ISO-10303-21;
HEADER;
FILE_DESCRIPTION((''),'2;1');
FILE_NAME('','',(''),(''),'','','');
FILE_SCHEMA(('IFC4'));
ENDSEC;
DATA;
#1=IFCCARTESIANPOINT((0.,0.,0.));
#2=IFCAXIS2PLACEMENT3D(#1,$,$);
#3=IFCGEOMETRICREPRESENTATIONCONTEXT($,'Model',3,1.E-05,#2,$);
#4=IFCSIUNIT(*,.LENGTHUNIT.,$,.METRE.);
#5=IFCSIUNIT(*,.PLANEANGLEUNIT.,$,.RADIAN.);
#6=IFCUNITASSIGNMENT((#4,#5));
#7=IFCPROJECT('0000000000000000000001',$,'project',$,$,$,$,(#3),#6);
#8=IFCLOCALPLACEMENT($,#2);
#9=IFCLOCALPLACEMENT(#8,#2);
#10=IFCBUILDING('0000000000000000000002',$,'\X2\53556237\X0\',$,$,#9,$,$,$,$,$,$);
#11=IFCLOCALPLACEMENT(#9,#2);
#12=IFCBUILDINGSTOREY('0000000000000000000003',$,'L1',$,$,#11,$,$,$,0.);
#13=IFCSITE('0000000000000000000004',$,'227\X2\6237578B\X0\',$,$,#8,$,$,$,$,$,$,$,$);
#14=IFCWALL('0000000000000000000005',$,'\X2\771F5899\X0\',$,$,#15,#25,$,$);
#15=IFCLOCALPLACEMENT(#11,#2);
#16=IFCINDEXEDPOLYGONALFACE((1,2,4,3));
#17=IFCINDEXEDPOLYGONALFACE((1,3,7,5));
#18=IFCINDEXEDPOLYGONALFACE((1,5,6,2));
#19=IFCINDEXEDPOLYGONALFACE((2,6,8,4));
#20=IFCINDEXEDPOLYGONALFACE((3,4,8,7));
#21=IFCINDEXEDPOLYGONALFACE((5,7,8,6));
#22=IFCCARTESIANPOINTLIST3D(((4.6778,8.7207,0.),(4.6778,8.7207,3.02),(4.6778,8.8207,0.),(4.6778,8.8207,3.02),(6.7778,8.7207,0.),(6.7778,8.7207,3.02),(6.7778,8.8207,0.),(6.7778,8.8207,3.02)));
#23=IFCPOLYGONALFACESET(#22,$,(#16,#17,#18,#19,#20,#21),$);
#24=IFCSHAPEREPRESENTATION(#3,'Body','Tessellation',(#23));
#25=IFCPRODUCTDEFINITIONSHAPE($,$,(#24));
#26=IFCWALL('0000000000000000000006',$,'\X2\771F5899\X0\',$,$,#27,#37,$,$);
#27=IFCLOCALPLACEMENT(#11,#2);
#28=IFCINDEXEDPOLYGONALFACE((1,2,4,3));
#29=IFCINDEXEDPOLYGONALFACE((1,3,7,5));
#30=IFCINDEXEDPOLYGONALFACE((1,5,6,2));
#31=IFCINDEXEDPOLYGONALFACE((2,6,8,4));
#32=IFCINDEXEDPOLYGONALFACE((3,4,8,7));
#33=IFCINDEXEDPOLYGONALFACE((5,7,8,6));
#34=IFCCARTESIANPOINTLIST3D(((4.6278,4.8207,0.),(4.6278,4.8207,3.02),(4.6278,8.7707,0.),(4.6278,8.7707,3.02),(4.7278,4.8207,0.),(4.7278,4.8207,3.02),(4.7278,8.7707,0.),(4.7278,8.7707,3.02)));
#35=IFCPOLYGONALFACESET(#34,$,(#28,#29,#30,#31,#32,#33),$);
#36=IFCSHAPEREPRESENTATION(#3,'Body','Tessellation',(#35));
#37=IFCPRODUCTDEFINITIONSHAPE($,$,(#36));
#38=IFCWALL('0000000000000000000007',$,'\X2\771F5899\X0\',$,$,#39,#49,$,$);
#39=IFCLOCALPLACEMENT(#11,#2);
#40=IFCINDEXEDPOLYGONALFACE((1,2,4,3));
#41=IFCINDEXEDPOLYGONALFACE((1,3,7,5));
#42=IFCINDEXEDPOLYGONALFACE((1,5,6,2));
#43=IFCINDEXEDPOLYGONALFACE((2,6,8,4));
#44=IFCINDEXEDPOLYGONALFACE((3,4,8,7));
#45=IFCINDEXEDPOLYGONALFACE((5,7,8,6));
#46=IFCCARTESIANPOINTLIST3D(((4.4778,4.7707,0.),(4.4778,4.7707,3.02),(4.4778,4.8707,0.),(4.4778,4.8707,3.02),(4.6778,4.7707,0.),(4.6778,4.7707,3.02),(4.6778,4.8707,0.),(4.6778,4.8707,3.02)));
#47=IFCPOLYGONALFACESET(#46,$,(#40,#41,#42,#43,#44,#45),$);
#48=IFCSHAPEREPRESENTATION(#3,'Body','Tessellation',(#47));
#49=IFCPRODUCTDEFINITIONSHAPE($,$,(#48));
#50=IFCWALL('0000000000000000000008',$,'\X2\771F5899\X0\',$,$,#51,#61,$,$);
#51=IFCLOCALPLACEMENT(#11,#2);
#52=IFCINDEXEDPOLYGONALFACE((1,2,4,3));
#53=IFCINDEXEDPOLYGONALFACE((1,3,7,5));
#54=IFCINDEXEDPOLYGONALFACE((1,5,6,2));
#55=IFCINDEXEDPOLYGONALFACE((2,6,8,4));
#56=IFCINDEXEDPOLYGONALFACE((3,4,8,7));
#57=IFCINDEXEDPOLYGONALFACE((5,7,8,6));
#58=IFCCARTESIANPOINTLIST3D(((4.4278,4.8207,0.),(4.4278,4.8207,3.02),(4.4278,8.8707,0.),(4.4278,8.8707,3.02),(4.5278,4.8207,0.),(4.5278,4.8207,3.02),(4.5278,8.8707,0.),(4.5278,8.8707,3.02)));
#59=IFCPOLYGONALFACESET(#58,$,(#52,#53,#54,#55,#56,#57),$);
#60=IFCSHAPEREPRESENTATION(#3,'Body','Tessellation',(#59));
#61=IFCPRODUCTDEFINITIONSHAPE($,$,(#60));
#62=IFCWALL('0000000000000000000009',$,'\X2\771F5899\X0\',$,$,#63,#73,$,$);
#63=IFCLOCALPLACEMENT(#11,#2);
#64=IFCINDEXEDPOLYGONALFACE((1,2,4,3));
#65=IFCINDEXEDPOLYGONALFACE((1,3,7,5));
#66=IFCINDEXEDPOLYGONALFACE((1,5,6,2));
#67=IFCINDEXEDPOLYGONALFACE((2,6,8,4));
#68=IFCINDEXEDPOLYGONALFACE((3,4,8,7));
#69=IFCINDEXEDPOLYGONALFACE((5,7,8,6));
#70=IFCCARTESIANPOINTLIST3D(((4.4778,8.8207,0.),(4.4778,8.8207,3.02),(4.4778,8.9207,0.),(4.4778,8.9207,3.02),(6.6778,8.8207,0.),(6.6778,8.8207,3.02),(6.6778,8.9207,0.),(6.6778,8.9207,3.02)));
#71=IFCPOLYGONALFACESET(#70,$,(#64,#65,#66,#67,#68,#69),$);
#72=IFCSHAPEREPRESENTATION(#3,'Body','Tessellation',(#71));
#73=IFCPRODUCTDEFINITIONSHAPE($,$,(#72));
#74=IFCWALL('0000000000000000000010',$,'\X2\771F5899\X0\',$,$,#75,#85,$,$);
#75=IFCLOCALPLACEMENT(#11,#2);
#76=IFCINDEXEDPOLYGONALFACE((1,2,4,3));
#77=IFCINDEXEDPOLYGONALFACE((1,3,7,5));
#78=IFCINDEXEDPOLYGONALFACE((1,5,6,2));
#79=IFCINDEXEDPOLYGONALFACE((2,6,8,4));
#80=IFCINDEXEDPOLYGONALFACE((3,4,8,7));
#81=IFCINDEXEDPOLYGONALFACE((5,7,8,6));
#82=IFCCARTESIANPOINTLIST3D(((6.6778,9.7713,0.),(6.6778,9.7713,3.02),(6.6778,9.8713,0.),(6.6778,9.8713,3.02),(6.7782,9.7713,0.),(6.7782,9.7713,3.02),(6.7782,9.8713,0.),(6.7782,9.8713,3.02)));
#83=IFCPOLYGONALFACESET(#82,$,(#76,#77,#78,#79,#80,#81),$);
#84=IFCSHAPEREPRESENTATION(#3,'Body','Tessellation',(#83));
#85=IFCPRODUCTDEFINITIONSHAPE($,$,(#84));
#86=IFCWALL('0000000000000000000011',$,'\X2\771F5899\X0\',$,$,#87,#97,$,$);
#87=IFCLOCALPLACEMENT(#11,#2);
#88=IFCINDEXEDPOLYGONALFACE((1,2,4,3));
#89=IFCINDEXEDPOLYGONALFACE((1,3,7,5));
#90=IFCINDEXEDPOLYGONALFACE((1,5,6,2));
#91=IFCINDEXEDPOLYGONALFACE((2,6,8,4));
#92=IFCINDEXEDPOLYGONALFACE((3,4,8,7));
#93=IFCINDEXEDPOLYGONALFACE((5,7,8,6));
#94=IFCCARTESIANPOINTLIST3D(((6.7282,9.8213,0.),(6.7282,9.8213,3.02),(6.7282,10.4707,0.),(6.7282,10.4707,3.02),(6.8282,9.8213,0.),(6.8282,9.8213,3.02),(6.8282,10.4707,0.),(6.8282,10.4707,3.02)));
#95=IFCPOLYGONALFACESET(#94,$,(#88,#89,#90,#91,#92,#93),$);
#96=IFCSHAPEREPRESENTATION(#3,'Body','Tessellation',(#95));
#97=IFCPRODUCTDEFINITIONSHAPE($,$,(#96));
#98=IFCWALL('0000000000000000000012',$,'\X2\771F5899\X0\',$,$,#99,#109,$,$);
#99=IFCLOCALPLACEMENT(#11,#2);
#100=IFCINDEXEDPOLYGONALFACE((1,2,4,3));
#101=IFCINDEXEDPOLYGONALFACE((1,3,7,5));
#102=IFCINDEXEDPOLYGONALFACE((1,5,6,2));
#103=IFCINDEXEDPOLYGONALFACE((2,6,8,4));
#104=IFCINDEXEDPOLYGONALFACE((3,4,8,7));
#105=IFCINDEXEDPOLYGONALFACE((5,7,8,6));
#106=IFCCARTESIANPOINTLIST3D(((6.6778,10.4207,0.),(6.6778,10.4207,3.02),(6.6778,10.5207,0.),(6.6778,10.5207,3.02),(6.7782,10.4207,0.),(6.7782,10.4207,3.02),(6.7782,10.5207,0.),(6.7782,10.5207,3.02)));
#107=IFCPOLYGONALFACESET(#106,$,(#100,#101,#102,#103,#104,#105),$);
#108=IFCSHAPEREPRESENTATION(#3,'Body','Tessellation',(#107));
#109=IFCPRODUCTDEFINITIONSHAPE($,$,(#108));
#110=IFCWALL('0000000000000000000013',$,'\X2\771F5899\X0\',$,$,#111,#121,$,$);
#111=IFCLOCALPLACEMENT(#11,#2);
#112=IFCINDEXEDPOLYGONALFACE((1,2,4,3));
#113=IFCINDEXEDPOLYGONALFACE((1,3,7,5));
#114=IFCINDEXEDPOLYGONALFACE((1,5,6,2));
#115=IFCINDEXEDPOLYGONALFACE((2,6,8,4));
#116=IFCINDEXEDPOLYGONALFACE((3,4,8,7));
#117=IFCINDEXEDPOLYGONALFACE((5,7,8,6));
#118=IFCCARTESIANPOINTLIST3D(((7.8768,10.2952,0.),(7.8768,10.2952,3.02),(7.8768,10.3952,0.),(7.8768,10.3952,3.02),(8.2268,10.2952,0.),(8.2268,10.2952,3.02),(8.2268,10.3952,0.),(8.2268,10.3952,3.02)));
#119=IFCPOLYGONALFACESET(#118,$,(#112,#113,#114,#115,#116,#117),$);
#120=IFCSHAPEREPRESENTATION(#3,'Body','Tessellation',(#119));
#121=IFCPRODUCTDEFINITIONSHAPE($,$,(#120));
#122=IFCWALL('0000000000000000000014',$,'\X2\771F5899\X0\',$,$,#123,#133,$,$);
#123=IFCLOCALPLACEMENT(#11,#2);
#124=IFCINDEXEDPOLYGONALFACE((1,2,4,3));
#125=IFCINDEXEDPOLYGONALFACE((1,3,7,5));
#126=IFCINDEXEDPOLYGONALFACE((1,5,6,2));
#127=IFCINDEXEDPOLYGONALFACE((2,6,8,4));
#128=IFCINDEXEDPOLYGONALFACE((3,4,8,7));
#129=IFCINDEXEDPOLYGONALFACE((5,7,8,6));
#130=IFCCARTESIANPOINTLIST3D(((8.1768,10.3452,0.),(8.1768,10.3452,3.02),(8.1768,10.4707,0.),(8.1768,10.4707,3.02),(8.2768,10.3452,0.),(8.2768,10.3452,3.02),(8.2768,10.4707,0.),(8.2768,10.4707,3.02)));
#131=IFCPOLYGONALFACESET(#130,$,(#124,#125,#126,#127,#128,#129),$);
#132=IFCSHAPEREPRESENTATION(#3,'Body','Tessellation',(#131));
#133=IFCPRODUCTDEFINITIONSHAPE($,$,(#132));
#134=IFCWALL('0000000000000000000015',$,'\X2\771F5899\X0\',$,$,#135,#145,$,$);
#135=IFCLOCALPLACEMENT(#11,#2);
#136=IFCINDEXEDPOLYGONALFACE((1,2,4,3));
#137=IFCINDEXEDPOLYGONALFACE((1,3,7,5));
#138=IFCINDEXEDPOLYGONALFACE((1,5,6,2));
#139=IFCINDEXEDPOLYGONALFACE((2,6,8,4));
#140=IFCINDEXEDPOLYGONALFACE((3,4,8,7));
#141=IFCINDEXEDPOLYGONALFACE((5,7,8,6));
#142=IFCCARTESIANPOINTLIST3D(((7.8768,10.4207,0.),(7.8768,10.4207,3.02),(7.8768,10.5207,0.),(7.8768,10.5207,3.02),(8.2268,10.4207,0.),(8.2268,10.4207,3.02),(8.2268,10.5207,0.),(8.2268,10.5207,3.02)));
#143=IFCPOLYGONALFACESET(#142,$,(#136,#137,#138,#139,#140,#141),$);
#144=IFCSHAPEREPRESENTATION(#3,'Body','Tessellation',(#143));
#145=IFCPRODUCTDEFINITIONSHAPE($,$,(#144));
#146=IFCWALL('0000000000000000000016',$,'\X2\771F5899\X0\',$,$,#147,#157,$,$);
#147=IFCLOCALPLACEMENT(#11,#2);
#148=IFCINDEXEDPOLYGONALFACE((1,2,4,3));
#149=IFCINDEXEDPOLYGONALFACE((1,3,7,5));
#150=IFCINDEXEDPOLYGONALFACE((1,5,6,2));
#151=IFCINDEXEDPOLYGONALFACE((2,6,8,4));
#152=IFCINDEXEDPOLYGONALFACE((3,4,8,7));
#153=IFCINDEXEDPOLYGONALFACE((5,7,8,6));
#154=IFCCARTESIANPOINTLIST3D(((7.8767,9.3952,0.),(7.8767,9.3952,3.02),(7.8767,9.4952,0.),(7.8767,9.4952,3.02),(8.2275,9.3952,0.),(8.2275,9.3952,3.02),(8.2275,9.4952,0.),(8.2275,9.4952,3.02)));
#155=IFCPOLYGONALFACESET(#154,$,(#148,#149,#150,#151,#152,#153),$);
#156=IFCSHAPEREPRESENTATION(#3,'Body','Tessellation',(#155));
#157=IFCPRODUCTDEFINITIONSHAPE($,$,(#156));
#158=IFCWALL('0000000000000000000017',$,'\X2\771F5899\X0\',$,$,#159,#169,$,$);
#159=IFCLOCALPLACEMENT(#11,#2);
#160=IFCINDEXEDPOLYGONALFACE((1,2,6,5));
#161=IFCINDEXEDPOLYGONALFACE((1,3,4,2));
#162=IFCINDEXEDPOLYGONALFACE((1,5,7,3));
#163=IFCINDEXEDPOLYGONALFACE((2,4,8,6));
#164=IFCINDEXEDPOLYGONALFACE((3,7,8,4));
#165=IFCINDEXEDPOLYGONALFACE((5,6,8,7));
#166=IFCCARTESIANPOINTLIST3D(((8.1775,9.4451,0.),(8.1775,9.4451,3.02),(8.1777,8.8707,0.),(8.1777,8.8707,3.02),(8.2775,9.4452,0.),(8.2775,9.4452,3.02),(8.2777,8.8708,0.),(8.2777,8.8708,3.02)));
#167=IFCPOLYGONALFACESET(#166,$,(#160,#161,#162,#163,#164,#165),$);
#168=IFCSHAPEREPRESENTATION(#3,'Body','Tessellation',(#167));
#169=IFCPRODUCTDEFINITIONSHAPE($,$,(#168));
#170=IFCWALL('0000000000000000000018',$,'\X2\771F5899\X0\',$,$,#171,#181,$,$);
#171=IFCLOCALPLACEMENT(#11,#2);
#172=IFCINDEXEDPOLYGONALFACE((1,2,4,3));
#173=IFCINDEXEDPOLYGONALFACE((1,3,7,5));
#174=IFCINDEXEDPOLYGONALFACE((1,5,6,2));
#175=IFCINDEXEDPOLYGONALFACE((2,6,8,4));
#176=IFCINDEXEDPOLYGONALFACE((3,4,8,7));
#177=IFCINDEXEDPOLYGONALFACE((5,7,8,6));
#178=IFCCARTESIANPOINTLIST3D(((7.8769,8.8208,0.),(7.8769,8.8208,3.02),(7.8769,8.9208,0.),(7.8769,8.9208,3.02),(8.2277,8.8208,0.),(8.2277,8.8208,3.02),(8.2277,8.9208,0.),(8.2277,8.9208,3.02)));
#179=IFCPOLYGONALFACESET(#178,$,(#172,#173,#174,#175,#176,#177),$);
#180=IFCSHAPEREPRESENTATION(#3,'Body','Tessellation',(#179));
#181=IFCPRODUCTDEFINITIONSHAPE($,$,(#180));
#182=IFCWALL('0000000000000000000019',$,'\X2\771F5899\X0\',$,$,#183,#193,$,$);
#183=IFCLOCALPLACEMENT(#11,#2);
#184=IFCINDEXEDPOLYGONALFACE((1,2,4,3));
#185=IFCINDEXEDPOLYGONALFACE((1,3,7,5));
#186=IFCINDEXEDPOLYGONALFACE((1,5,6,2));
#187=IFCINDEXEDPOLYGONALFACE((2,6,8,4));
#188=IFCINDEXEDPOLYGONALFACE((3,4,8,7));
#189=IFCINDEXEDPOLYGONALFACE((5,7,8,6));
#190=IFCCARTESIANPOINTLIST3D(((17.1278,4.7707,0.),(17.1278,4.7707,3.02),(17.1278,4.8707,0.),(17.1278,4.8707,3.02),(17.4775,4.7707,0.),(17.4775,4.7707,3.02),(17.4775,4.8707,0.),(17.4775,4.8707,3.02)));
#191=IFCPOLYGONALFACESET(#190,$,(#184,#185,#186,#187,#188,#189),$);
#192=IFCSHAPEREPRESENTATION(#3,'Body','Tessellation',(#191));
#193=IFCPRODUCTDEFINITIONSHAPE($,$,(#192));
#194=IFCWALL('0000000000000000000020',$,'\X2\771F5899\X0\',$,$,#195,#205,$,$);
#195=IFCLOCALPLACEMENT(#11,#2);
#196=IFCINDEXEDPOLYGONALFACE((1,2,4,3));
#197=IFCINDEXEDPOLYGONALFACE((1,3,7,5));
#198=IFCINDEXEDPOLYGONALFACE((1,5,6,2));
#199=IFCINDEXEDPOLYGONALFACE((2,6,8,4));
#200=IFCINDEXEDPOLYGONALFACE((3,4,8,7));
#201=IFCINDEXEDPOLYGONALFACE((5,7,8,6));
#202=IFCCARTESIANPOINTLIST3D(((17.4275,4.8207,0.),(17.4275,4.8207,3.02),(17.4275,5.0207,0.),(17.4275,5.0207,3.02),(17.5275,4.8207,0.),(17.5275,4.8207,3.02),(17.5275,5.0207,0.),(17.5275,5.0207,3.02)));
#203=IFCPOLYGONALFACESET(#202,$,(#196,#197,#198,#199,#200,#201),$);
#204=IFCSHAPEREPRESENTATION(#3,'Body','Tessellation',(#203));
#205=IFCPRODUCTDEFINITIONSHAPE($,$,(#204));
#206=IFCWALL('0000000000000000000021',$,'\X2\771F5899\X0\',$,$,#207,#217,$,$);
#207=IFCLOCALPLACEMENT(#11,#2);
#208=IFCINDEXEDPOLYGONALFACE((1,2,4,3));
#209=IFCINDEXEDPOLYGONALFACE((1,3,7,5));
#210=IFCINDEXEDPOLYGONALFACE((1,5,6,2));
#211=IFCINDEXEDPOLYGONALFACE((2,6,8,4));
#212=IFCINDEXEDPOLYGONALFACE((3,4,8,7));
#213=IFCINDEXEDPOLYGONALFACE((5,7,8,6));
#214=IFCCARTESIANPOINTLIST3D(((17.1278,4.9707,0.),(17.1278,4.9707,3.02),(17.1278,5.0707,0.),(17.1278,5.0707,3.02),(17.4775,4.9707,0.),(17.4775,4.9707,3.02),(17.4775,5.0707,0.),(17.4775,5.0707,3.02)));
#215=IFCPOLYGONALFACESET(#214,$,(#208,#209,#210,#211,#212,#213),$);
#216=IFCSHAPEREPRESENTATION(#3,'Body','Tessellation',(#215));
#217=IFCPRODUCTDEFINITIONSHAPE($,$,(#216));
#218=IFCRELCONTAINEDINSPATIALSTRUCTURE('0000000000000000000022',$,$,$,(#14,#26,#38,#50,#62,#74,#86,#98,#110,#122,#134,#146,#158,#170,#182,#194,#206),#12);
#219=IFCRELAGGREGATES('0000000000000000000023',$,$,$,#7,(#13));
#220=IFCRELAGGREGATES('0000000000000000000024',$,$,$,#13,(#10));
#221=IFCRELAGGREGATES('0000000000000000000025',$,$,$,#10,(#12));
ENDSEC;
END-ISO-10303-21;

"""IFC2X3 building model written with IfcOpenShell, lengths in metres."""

from ifc_helpers import new_model, si_unit, origin, place, context, project, spatial, polyline, outline, extrude, element, save


model = new_model("IFC2X3")

# Units and contexts
model_context = context("Model", 3, precision=1e-05, world=origin())
ifc_project = project(units=[si_unit("LENGTHUNIT", "METRE"), si_unit("PLANEANGLEUNIT", "RADIAN")], contexts=[model_context])

# Site, building, storey
site_placement = place(None, origin())
site = spatial("IfcSite", under=ifc_project, at=site_placement, Name="227户型")
building_placement = place(site_placement, origin())
building = spatial("IfcBuilding", under=site, at=building_placement, Name="单户")
storey_placement = place(building_placement, origin())
storey = spatial("IfcBuildingStorey", under=building, at=storey_placement, Name="L1", Elevation=0.0)

# Walls
wall_1_placement = place(storey_placement, origin())
element("IfcWall", 1, at=wall_1_placement, inside=storey, Name="真墙", context=model_context, shape_type="SweptSolid", body=[
    extrude(outline(polyline([(6.7778, 8.7207), (4.6778, 8.7207), (4.6778, 8.8207), (6.7778, 8.8207), (6.7778, 8.7207)])), origin(), (0.0, 0.0, 1.0), 3.02),
])
wall_2_placement = place(storey_placement, origin())
element("IfcWall", 2, at=wall_2_placement, inside=storey, Name="真墙", context=model_context, shape_type="SweptSolid", body=[
    extrude(outline(polyline([(4.7278, 8.7707), (4.7278, 4.8207), (4.6278, 4.8207), (4.6278, 8.7707), (4.7278, 8.7707)])), origin(), (0.0, 0.0, 1.0), 3.02),
])
wall_3_placement = place(storey_placement, origin())
element("IfcWall", 3, at=wall_3_placement, inside=storey, Name="真墙", context=model_context, shape_type="SweptSolid", body=[
    extrude(outline(polyline([(4.6778, 4.7707), (4.4778, 4.7707), (4.4778, 4.8707), (4.6778, 4.8707), (4.6778, 4.7707)])), origin(), (0.0, 0.0, 1.0), 3.02),
])
wall_4_placement = place(storey_placement, origin())
element("IfcWall", 4, at=wall_4_placement, inside=storey, Name="真墙", context=model_context, shape_type="SweptSolid", body=[
    extrude(outline(polyline([(4.4278, 4.8207), (4.4278, 8.8707), (4.5278, 8.8707), (4.5278, 4.8207), (4.4278, 4.8207)])), origin(), (0.0, 0.0, 1.0), 3.02),
])
wall_5_placement = place(storey_placement, origin())
element("IfcWall", 5, at=wall_5_placement, inside=storey, Name="真墙", context=model_context, shape_type="SweptSolid", body=[
    extrude(outline(polyline([(4.4778, 8.9207), (6.6778, 8.9207), (6.6778, 8.8207), (4.4778, 8.8207), (4.4778, 8.9207)])), origin(), (0.0, 0.0, 1.0), 3.02),
])
wall_6_placement = place(storey_placement, origin())
element("IfcWall", 6, at=wall_6_placement, inside=storey, Name="真墙", context=model_context, shape_type="SweptSolid", body=[
    extrude(outline(polyline([(6.6778, 9.8713), (6.7782, 9.8713), (6.7782, 9.7713), (6.6778, 9.7713), (6.6778, 9.8713)])), origin(), (0.0, 0.0, 1.0), 3.02),
])
wall_7_placement = place(storey_placement, origin())
element("IfcWall", 7, at=wall_7_placement, inside=storey, Name="真墙", context=model_context, shape_type="SweptSolid", body=[
    extrude(outline(polyline([(6.7282, 9.8213), (6.7282, 10.4707), (6.8282, 10.4707), (6.8282, 9.8213), (6.7282, 9.8213)])), origin(), (0.0, 0.0, 1.0), 3.02),
])
wall_8_placement = place(storey_placement, origin())
element("IfcWall", 8, at=wall_8_placement, inside=storey, Name="真墙", context=model_context, shape_type="SweptSolid", body=[
    extrude(outline(polyline([(6.7782, 10.4207), (6.6778, 10.4207), (6.6778, 10.5207), (6.7782, 10.5207), (6.7782, 10.4207)])), origin(), (0.0, 0.0, 1.0), 3.02),
])
wall_9_placement = place(storey_placement, origin())
element("IfcWall", 9, at=wall_9_placement, inside=storey, Name="真墙", context=model_context, shape_type="SweptSolid", body=[
    extrude(outline(polyline([(7.8768, 10.3952), (8.2268, 10.3952), (8.2268, 10.2952), (7.8768, 10.2952), (7.8768, 10.3952)])), origin(), (0.0, 0.0, 1.0), 3.02),
])
wall_10_placement = place(storey_placement, origin())
element("IfcWall", 10, at=wall_10_placement, inside=storey, Name="真墙", context=model_context, shape_type="SweptSolid", body=[
    extrude(outline(polyline([(8.1768, 10.3452), (8.1768, 10.4707), (8.2768, 10.4707), (8.2768, 10.3452), (8.1768, 10.3452)])), origin(), (0.0, 0.0, 1.0), 3.02),
])
wall_11_placement = place(storey_placement, origin())
element("IfcWall", 11, at=wall_11_placement, inside=storey, Name="真墙", context=model_context, shape_type="SweptSolid", body=[
    extrude(outline(polyline([(8.2268, 10.4207), (7.8768, 10.4207), (7.8768, 10.5207), (8.2268, 10.5207), (8.2268, 10.4207)])), origin(), (0.0, 0.0, 1.0), 3.02),
])
wall_12_placement = place(storey_placement, origin())
element("IfcWall", 12, at=wall_12_placement, inside=storey, Name="真墙", context=model_context, shape_type="SweptSolid", body=[
    extrude(outline(polyline([(7.8767, 9.4952), (8.2275, 9.4952), (8.2275, 9.3952), (7.8767, 9.3952), (7.8767, 9.4952)])), origin(), (0.0, 0.0, 1.0), 3.02),
])
wall_13_placement = place(storey_placement, origin())
element("IfcWall", 13, at=wall_13_placement, inside=storey, Name="真墙", context=model_context, shape_type="SweptSolid", body=[
    extrude(outline(polyline([(8.2775, 9.4452), (8.2777, 8.8708), (8.1777, 8.8707), (8.1775, 9.4451), (8.2775, 9.4452)])), origin(), (0.0, 0.0, 1.0), 3.02),
])
wall_14_placement = place(storey_placement, origin())
element("IfcWall", 14, at=wall_14_placement, inside=storey, Name="真墙", context=model_context, shape_type="SweptSolid", body=[
    extrude(outline(polyline([(8.2277, 8.8208), (7.8769, 8.8208), (7.8769, 8.9208), (8.2277, 8.9208), (8.2277, 8.8208)])), origin(), (0.0, 0.0, 1.0), 3.02),
])
wall_15_placement = place(storey_placement, origin())
element("IfcWall", 15, at=wall_15_placement, inside=storey, Name="真墙", context=model_context, shape_type="SweptSolid", body=[
    extrude(outline(polyline([(17.1278, 4.8707), (17.4775, 4.8707), (17.4775, 4.7707), (17.1278, 4.7707), (17.1278, 4.8707)])), origin(), (0.0, 0.0, 1.0), 3.02),
])
wall_16_placement = place(storey_placement, origin())
element("IfcWall", 16, at=wall_16_placement, inside=storey, Name="真墙", context=model_context, shape_type="SweptSolid", body=[
    extrude(outline(polyline([(17.4275, 4.8207), (17.4275, 5.0207), (17.5275, 5.0207), (17.5275, 4.8207), (17.4275, 4.8207)])), origin(), (0.0, 0.0, 1.0), 3.02),
])
wall_17_placement = place(storey_placement, origin())
element("IfcWall", 17, at=wall_17_placement, inside=storey, Name="真墙", context=model_context, shape_type="SweptSolid", body=[
    extrude(outline(polyline([(17.4775, 4.9707), (17.1278, 4.9707), (17.1278, 5.0707), (17.4775, 5.0707), (17.4775, 4.9707)])), origin(), (0.0, 0.0, 1.0), 3.02),
])

save(model, "model.ifc")
